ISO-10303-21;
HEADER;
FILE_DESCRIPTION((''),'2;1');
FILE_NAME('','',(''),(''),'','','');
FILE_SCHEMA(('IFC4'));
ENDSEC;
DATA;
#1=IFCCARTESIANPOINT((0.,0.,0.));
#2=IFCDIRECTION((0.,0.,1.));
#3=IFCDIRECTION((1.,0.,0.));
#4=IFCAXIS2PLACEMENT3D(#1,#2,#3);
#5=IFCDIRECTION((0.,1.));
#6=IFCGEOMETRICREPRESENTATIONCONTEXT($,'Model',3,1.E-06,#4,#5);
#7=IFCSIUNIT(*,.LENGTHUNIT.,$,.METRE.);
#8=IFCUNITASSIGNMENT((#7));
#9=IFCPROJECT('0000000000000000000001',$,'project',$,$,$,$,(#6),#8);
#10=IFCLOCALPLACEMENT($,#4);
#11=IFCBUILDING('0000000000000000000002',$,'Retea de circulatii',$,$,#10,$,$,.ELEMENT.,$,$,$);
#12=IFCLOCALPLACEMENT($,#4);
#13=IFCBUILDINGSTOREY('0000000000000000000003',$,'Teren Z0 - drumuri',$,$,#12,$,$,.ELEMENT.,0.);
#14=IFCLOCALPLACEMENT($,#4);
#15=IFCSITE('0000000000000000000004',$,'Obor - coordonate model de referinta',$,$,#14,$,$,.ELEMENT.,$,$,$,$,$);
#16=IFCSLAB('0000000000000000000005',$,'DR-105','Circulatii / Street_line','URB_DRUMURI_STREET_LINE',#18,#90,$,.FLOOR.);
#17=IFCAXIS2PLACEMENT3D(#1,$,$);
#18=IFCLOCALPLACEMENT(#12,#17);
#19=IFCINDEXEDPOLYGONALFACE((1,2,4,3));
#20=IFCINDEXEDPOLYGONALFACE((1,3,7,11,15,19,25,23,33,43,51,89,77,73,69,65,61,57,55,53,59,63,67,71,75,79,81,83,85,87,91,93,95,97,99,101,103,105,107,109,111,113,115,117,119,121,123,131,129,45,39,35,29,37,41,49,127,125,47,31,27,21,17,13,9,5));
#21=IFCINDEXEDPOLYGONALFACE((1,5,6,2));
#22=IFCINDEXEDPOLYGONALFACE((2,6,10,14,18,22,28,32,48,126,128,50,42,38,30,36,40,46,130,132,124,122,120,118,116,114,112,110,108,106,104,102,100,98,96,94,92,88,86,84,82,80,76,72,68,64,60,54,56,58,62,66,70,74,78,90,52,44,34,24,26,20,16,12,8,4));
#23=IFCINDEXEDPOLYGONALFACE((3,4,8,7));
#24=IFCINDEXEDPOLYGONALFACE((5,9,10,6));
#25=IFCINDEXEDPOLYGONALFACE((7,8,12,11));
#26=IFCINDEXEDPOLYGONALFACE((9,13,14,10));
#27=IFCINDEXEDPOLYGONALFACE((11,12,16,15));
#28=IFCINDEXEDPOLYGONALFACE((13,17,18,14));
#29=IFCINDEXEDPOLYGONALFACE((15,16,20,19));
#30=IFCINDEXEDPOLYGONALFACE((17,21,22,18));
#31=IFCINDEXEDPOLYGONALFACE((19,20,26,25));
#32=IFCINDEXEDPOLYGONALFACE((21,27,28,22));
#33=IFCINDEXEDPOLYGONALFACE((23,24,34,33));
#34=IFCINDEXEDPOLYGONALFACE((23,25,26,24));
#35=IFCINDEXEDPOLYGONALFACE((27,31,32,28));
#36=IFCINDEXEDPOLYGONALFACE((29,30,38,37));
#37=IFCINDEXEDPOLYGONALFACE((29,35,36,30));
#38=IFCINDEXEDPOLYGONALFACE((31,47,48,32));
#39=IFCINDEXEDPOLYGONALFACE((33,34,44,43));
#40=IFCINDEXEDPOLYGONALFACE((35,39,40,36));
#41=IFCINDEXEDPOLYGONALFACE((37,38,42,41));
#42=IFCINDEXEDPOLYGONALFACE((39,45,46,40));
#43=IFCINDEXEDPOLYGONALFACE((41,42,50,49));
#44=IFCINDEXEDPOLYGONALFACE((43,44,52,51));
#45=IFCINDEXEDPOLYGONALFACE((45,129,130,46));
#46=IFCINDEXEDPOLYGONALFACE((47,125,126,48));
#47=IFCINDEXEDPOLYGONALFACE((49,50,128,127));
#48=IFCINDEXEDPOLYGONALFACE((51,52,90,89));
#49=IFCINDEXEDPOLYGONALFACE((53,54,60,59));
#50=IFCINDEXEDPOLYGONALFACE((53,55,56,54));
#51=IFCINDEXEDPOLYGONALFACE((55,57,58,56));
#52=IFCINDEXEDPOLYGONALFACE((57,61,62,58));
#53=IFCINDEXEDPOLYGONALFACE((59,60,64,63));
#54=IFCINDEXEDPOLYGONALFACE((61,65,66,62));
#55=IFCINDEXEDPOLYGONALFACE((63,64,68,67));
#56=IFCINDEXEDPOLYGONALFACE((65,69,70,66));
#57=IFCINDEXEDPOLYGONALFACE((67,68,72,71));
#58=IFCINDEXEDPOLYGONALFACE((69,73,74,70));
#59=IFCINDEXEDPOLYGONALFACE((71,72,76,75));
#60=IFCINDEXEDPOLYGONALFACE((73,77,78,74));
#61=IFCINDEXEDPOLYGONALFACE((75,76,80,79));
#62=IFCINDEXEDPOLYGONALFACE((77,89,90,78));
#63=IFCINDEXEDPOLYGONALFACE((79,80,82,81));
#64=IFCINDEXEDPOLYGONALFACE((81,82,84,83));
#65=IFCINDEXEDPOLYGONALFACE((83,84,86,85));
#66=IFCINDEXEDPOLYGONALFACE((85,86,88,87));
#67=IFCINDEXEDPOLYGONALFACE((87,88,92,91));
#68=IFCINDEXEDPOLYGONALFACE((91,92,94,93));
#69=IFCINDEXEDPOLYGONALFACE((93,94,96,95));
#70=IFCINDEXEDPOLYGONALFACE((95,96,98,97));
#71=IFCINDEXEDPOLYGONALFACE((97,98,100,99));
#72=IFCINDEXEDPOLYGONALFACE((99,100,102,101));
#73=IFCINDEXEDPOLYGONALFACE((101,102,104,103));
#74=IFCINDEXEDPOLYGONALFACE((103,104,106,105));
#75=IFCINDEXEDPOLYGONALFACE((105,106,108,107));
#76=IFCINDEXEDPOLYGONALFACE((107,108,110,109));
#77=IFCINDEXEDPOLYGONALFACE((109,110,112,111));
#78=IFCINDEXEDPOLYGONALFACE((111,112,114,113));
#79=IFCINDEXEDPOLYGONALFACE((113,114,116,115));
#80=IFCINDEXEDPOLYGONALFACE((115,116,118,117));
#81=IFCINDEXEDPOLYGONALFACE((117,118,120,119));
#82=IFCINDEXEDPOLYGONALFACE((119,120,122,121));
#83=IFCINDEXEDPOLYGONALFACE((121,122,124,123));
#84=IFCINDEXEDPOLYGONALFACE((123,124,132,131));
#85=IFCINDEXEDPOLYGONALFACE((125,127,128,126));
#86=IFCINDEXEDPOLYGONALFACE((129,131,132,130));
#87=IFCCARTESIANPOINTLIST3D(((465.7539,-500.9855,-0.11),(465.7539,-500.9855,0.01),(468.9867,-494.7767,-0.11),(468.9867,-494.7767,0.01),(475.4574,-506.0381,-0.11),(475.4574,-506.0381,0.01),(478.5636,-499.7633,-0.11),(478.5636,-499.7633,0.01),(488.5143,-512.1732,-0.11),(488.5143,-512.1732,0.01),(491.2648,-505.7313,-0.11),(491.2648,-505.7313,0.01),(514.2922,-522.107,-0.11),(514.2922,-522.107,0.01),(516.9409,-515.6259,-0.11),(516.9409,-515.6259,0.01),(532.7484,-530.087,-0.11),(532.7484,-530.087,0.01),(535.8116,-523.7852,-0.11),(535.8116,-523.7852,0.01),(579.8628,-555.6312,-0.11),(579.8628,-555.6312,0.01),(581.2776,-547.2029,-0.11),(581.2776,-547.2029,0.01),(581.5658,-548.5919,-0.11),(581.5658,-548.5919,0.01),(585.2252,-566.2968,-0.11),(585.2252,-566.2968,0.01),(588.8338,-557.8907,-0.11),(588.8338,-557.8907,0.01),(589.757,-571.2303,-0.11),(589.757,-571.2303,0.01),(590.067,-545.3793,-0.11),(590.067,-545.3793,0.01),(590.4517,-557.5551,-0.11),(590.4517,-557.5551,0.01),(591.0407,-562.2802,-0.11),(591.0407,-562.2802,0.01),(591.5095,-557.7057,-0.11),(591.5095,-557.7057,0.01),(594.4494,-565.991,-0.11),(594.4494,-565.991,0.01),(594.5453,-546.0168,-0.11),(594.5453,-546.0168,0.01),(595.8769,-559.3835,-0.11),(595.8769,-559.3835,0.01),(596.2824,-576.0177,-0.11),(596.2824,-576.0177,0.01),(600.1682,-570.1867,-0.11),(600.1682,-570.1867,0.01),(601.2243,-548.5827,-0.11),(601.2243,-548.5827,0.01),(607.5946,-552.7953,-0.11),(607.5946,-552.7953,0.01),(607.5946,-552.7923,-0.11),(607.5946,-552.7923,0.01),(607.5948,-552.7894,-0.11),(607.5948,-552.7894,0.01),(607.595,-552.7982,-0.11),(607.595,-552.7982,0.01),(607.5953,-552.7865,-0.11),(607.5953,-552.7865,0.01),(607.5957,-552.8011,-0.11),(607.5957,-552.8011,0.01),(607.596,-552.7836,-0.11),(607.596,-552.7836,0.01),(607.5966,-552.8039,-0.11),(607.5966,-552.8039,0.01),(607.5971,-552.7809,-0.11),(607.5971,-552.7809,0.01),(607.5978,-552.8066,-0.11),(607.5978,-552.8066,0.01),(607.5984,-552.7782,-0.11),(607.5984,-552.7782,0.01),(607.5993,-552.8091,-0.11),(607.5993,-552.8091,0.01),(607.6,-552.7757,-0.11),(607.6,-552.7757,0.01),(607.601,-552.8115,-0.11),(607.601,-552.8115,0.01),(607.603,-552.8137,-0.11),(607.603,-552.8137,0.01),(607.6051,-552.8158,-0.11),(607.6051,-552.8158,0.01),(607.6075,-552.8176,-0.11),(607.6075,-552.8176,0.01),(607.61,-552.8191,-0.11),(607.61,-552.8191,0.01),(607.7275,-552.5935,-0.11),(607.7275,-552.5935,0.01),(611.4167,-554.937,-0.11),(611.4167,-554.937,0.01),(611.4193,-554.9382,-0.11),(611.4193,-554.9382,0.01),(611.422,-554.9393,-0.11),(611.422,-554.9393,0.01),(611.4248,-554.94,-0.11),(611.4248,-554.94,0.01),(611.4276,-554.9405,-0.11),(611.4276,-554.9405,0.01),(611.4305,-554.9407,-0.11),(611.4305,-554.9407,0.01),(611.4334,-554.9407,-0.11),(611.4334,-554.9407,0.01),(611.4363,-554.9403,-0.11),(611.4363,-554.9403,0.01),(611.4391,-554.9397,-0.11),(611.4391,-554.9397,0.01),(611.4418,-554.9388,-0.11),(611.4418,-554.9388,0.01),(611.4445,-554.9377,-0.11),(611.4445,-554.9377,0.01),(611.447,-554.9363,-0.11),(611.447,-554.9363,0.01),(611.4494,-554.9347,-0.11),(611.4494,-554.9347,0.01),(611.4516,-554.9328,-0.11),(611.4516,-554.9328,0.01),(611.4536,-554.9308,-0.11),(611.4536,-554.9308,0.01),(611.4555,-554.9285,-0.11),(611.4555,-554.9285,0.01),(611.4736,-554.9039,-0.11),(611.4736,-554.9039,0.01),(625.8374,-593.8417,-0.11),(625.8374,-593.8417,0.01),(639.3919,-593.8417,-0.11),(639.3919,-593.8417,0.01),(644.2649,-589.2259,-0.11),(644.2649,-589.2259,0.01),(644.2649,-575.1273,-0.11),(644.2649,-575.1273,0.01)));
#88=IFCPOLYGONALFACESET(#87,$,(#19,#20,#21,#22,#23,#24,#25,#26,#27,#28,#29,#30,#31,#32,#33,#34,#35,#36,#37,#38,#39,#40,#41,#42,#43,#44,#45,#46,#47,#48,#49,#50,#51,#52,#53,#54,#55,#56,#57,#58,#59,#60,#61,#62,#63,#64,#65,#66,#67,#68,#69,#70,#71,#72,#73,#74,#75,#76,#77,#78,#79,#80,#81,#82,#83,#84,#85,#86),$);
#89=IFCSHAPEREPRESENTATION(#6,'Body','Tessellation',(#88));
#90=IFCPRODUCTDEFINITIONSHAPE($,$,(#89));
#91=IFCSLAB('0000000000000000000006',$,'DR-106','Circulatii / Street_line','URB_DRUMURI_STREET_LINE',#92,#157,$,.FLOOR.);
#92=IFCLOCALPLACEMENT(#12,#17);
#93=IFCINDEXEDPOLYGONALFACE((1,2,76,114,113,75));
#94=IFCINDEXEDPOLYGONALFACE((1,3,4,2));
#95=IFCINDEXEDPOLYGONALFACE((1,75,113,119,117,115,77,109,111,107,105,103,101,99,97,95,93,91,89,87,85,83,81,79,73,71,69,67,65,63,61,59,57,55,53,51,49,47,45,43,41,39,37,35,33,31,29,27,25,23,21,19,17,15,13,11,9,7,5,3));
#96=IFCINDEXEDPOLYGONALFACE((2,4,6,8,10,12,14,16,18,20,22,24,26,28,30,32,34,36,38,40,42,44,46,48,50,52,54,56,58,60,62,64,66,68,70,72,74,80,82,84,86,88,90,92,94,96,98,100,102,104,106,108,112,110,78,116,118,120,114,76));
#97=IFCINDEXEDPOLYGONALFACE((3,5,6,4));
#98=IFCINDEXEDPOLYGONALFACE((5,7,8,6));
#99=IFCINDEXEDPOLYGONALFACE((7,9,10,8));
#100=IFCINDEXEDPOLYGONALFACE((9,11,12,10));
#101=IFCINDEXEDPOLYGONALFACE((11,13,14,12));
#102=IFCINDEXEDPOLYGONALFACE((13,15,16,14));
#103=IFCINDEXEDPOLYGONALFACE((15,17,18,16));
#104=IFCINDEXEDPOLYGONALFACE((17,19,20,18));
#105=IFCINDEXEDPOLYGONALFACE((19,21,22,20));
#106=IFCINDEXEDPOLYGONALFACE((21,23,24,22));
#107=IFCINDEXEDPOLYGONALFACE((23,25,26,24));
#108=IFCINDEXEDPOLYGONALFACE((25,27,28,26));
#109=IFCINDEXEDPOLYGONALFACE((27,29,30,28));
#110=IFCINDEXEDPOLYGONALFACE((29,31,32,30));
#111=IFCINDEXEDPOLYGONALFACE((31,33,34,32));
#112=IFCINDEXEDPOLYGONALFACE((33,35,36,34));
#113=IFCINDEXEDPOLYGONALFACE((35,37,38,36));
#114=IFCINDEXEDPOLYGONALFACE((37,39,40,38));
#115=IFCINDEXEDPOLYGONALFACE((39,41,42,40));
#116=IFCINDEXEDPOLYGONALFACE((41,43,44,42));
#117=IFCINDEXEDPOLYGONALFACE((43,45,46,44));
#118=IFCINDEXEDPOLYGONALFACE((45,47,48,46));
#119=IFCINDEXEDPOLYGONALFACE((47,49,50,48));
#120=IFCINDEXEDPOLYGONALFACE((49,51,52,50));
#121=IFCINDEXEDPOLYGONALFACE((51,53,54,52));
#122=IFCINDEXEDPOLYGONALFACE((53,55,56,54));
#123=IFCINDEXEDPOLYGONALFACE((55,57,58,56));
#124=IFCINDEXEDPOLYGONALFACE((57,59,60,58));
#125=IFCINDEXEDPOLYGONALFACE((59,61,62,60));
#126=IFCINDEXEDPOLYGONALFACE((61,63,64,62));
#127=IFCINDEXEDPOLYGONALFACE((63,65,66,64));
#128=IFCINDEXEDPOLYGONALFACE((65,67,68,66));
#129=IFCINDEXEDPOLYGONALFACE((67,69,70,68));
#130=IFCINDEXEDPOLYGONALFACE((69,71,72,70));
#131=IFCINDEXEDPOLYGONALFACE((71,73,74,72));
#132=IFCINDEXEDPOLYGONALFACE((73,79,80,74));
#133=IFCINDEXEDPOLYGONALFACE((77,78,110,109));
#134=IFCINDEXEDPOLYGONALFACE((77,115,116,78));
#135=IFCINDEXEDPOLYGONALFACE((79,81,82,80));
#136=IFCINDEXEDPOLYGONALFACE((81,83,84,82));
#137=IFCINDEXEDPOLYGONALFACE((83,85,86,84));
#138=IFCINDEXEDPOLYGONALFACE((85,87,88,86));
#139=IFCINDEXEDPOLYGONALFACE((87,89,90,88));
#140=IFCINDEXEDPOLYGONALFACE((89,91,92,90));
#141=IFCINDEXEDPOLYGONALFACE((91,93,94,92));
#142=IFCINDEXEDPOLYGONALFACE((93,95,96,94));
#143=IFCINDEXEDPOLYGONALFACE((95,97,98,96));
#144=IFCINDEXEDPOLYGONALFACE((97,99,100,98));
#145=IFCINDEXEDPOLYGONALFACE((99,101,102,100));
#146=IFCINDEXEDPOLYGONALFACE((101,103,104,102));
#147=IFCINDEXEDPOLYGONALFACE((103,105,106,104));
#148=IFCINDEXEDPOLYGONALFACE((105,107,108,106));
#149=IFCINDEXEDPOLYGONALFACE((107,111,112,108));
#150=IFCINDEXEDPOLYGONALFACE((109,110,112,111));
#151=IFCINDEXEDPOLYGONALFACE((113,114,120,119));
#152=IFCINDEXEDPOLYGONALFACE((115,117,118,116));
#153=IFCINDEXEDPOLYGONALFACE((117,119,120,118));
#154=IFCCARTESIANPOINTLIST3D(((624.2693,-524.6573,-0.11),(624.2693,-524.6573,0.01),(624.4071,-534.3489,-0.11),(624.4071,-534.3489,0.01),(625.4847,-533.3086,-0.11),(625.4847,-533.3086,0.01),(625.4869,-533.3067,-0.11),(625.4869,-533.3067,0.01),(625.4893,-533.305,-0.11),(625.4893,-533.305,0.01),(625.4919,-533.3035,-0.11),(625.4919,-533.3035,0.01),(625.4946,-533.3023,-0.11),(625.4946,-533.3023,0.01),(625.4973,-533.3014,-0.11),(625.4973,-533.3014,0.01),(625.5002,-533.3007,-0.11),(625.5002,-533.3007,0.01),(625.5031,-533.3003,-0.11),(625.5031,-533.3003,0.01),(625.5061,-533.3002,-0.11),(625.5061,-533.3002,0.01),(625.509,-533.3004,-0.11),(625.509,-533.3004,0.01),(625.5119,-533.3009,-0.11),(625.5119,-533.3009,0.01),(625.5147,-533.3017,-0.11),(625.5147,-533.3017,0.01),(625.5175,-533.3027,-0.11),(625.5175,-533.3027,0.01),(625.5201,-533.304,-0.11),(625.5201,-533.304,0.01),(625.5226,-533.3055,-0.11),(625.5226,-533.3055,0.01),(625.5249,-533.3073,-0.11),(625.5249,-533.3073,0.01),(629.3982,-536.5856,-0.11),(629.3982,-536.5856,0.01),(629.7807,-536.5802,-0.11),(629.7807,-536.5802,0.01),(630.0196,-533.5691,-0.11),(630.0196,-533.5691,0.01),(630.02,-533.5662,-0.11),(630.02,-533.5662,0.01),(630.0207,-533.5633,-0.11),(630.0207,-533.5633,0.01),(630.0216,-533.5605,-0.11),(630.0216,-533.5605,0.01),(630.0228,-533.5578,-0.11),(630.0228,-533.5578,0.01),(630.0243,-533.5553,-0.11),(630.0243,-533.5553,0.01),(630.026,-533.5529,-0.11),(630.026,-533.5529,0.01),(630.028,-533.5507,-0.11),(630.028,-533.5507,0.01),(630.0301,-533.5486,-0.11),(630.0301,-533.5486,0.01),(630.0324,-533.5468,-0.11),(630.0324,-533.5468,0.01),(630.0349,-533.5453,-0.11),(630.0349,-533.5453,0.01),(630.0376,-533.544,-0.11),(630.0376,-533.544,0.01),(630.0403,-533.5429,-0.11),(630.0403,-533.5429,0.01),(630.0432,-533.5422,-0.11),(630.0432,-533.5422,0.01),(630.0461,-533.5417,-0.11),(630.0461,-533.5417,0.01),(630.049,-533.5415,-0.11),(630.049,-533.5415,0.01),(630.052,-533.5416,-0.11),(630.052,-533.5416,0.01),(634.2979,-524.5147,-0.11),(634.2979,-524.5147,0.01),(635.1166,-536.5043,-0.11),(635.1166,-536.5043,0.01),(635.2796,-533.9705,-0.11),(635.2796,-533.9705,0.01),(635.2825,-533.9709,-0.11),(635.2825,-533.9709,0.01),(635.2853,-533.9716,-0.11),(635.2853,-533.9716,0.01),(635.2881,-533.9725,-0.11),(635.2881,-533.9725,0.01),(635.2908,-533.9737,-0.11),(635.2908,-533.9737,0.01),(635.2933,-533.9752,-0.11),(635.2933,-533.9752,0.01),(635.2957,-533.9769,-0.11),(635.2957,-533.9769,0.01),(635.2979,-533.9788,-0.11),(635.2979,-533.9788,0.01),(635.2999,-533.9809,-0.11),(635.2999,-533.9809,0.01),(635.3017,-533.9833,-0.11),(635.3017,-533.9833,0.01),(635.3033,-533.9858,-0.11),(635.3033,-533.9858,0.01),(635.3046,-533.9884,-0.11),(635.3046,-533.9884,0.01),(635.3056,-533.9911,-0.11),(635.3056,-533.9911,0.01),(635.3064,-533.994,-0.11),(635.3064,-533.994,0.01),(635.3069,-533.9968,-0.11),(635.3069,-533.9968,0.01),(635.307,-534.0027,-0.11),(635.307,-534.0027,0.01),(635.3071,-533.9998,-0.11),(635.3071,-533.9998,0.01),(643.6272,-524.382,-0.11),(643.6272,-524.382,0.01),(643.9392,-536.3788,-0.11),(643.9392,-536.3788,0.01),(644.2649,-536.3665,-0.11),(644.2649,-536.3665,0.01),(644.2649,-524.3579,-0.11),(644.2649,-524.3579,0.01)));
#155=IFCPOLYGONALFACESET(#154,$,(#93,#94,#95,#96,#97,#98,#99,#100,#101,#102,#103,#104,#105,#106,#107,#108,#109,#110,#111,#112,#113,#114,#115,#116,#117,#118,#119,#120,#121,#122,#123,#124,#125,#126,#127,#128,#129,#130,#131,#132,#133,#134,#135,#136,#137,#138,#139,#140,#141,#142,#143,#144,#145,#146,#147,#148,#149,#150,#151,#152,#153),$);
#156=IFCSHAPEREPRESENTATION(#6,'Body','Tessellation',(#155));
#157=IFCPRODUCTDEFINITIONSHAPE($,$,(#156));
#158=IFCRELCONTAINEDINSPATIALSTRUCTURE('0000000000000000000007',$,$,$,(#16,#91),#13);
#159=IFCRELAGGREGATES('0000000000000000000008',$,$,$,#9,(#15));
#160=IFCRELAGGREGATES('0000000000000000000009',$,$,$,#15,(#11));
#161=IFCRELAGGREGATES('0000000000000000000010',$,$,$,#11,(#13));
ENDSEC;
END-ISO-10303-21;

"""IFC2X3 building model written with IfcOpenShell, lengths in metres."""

from ifc_helpers import new_model, si_unit, direction, frame, origin_with_axes, place, context, project, spatial, polyline, outline, extrude, element, save


model = new_model("IFC2X3")

# Units and contexts
model_context = context("Model", 3, precision=1e-06, world=origin_with_axes(), true_north=direction((0.0, 1.0)))
ifc_project = project(units=[si_unit("LENGTHUNIT", "METRE")], contexts=[model_context])

# Site, building, storey
site_placement = place(None, origin_with_axes())
site = spatial("IfcSite", under=ifc_project, at=site_placement, Name="Obor - coordonate model de referinta", CompositionType="ELEMENT")
building_placement = place(None, origin_with_axes())
building = spatial("IfcBuilding", under=site, at=building_placement, Name="Retea de circulatii", CompositionType="ELEMENT")
storey_placement = place(None, origin_with_axes())
storey = spatial("IfcBuildingStorey", under=building, at=storey_placement, Name="Teren Z0 - drumuri", CompositionType="ELEMENT", Elevation=0.0)

# Slabs
slab_1_placement = place(None, origin_with_axes())
element("IfcSlab", 1, at=slab_1_placement, inside=storey, Name="DR-105", Description="Circulatii / Street_line", ObjectType="URB_DRUMURI_STREET_LINE", PredefinedType="FLOOR", context=model_context, shape_type="SweptSolid", body=[
    extrude(outline(polyline([(585.2252, -566.2968), (589.757, -571.2303), (596.2824, -576.0177), (625.8374, -593.8417), (639.3919, -593.8417), (600.1682, -570.1867), (594.4494, -565.991), (591.0407, -562.2802), (588.8338, -557.8907), (590.4517, -557.5551), (591.5095, -557.7057), (595.8769, -559.3835), (644.2649, -589.2259), (644.2649, -575.1273), (611.4736, -554.9039), (611.4555, -554.9285), (611.4536, -554.9308), (611.4516, -554.9328), (611.4494, -554.9347), (611.447, -554.9363), (611.4445, -554.9377), (611.4418, -554.9388), (611.4391, -554.9397), (611.4363, -554.9403), (611.4334, -554.9407), (611.4305, -554.9407), (611.4276, -554.9405), (611.4248, -554.94), (611.422, -554.9393), (611.4193, -554.9382), (611.4167, -554.937), (607.61, -552.8191), (607.6075, -552.8176), (607.6051, -552.8158), (607.603, -552.8137), (607.601, -552.8115), (607.5993, -552.8091), (607.5978, -552.8066), (607.5966, -552.8039), (607.5957, -552.8011), (607.595, -552.7982), (607.5946, -552.7953), (607.5946, -552.7923), (607.5948, -552.7894), (607.5953, -552.7865), (607.596, -552.7836), (607.5971, -552.7809), (607.5984, -552.7782), (607.6, -552.7757), (607.7275, -552.5935), (601.2243, -548.5827), (594.5453, -546.0168), (590.067, -545.3793), (581.2776, -547.2029), (581.5658, -548.5919), (535.8116, -523.7852), (516.9409, -515.6259), (491.2648, -505.7313), (478.5636, -499.7633), (468.9867, -494.7767), (465.7539, -500.9855), (475.4574, -506.0381), (488.5143, -512.1732), (514.2922, -522.107), (532.7484, -530.087), (579.8628, -555.6312), (585.2252, -566.2968)])), frame((0.0, 0.0, -0.11), z_axis=(0.0, 0.0, 1.0), x_axis=(1.0, 0.0, 0.0)), (0.0, 0.0, 1.0), 0.12),
])
slab_2_placement = place(None, origin_with_axes())
element("IfcSlab", 2, at=slab_2_placement, inside=storey, Name="DR-106", Description="Circulatii / Street_line", ObjectType="URB_DRUMURI_STREET_LINE", PredefinedType="FLOOR", context=model_context, shape_type="SweptSolid", body=[
    extrude(outline(polyline([(635.3071, -533.9998), (635.307, -534.0027), (635.1166, -536.5043), (643.9392, -536.3788), (644.2649, -536.3665), (644.2649, -524.3579), (643.6272, -524.382), (634.2979, -524.5147), (624.2693, -524.6573), (624.4071, -534.3489), (625.4847, -533.3086), (625.4869, -533.3067), (625.4893, -533.305), (625.4919, -533.3035), (625.4946, -533.3023), (625.4973, -533.3014), (625.5002, -533.3007), (625.5031, -533.3003), (625.5061, -533.3002), (625.509, -533.3004), (625.5119, -533.3009), (625.5147, -533.3017), (625.5175, -533.3027), (625.5201, -533.304), (625.5226, -533.3055), (625.5249, -533.3073), (629.3982, -536.5856), (629.7807, -536.5802), (630.0196, -533.5691), (630.02, -533.5662), (630.0207, -533.5633), (630.0216, -533.5605), (630.0228, -533.5578), (630.0243, -533.5553), (630.026, -533.5529), (630.028, -533.5507), (630.0301, -533.5486), (630.0324, -533.5468), (630.0349, -533.5453), (630.0376, -533.544), (630.0403, -533.5429), (630.0432, -533.5422), (630.0461, -533.5417), (630.049, -533.5415), (630.052, -533.5416), (635.2796, -533.9705), (635.2825, -533.9709), (635.2853, -533.9716), (635.2881, -533.9725), (635.2908, -533.9737), (635.2933, -533.9752), (635.2957, -533.9769), (635.2979, -533.9788), (635.2999, -533.9809), (635.3017, -533.9833), (635.3033, -533.9858), (635.3046, -533.9884), (635.3056, -533.9911), (635.3064, -533.994), (635.3069, -533.9968), (635.3071, -533.9998)])), frame((0.0, 0.0, -0.11), z_axis=(0.0, 0.0, 1.0), x_axis=(1.0, 0.0, 0.0)), (0.0, 0.0, 1.0), 0.12),
])

save(model, "model.ifc")
